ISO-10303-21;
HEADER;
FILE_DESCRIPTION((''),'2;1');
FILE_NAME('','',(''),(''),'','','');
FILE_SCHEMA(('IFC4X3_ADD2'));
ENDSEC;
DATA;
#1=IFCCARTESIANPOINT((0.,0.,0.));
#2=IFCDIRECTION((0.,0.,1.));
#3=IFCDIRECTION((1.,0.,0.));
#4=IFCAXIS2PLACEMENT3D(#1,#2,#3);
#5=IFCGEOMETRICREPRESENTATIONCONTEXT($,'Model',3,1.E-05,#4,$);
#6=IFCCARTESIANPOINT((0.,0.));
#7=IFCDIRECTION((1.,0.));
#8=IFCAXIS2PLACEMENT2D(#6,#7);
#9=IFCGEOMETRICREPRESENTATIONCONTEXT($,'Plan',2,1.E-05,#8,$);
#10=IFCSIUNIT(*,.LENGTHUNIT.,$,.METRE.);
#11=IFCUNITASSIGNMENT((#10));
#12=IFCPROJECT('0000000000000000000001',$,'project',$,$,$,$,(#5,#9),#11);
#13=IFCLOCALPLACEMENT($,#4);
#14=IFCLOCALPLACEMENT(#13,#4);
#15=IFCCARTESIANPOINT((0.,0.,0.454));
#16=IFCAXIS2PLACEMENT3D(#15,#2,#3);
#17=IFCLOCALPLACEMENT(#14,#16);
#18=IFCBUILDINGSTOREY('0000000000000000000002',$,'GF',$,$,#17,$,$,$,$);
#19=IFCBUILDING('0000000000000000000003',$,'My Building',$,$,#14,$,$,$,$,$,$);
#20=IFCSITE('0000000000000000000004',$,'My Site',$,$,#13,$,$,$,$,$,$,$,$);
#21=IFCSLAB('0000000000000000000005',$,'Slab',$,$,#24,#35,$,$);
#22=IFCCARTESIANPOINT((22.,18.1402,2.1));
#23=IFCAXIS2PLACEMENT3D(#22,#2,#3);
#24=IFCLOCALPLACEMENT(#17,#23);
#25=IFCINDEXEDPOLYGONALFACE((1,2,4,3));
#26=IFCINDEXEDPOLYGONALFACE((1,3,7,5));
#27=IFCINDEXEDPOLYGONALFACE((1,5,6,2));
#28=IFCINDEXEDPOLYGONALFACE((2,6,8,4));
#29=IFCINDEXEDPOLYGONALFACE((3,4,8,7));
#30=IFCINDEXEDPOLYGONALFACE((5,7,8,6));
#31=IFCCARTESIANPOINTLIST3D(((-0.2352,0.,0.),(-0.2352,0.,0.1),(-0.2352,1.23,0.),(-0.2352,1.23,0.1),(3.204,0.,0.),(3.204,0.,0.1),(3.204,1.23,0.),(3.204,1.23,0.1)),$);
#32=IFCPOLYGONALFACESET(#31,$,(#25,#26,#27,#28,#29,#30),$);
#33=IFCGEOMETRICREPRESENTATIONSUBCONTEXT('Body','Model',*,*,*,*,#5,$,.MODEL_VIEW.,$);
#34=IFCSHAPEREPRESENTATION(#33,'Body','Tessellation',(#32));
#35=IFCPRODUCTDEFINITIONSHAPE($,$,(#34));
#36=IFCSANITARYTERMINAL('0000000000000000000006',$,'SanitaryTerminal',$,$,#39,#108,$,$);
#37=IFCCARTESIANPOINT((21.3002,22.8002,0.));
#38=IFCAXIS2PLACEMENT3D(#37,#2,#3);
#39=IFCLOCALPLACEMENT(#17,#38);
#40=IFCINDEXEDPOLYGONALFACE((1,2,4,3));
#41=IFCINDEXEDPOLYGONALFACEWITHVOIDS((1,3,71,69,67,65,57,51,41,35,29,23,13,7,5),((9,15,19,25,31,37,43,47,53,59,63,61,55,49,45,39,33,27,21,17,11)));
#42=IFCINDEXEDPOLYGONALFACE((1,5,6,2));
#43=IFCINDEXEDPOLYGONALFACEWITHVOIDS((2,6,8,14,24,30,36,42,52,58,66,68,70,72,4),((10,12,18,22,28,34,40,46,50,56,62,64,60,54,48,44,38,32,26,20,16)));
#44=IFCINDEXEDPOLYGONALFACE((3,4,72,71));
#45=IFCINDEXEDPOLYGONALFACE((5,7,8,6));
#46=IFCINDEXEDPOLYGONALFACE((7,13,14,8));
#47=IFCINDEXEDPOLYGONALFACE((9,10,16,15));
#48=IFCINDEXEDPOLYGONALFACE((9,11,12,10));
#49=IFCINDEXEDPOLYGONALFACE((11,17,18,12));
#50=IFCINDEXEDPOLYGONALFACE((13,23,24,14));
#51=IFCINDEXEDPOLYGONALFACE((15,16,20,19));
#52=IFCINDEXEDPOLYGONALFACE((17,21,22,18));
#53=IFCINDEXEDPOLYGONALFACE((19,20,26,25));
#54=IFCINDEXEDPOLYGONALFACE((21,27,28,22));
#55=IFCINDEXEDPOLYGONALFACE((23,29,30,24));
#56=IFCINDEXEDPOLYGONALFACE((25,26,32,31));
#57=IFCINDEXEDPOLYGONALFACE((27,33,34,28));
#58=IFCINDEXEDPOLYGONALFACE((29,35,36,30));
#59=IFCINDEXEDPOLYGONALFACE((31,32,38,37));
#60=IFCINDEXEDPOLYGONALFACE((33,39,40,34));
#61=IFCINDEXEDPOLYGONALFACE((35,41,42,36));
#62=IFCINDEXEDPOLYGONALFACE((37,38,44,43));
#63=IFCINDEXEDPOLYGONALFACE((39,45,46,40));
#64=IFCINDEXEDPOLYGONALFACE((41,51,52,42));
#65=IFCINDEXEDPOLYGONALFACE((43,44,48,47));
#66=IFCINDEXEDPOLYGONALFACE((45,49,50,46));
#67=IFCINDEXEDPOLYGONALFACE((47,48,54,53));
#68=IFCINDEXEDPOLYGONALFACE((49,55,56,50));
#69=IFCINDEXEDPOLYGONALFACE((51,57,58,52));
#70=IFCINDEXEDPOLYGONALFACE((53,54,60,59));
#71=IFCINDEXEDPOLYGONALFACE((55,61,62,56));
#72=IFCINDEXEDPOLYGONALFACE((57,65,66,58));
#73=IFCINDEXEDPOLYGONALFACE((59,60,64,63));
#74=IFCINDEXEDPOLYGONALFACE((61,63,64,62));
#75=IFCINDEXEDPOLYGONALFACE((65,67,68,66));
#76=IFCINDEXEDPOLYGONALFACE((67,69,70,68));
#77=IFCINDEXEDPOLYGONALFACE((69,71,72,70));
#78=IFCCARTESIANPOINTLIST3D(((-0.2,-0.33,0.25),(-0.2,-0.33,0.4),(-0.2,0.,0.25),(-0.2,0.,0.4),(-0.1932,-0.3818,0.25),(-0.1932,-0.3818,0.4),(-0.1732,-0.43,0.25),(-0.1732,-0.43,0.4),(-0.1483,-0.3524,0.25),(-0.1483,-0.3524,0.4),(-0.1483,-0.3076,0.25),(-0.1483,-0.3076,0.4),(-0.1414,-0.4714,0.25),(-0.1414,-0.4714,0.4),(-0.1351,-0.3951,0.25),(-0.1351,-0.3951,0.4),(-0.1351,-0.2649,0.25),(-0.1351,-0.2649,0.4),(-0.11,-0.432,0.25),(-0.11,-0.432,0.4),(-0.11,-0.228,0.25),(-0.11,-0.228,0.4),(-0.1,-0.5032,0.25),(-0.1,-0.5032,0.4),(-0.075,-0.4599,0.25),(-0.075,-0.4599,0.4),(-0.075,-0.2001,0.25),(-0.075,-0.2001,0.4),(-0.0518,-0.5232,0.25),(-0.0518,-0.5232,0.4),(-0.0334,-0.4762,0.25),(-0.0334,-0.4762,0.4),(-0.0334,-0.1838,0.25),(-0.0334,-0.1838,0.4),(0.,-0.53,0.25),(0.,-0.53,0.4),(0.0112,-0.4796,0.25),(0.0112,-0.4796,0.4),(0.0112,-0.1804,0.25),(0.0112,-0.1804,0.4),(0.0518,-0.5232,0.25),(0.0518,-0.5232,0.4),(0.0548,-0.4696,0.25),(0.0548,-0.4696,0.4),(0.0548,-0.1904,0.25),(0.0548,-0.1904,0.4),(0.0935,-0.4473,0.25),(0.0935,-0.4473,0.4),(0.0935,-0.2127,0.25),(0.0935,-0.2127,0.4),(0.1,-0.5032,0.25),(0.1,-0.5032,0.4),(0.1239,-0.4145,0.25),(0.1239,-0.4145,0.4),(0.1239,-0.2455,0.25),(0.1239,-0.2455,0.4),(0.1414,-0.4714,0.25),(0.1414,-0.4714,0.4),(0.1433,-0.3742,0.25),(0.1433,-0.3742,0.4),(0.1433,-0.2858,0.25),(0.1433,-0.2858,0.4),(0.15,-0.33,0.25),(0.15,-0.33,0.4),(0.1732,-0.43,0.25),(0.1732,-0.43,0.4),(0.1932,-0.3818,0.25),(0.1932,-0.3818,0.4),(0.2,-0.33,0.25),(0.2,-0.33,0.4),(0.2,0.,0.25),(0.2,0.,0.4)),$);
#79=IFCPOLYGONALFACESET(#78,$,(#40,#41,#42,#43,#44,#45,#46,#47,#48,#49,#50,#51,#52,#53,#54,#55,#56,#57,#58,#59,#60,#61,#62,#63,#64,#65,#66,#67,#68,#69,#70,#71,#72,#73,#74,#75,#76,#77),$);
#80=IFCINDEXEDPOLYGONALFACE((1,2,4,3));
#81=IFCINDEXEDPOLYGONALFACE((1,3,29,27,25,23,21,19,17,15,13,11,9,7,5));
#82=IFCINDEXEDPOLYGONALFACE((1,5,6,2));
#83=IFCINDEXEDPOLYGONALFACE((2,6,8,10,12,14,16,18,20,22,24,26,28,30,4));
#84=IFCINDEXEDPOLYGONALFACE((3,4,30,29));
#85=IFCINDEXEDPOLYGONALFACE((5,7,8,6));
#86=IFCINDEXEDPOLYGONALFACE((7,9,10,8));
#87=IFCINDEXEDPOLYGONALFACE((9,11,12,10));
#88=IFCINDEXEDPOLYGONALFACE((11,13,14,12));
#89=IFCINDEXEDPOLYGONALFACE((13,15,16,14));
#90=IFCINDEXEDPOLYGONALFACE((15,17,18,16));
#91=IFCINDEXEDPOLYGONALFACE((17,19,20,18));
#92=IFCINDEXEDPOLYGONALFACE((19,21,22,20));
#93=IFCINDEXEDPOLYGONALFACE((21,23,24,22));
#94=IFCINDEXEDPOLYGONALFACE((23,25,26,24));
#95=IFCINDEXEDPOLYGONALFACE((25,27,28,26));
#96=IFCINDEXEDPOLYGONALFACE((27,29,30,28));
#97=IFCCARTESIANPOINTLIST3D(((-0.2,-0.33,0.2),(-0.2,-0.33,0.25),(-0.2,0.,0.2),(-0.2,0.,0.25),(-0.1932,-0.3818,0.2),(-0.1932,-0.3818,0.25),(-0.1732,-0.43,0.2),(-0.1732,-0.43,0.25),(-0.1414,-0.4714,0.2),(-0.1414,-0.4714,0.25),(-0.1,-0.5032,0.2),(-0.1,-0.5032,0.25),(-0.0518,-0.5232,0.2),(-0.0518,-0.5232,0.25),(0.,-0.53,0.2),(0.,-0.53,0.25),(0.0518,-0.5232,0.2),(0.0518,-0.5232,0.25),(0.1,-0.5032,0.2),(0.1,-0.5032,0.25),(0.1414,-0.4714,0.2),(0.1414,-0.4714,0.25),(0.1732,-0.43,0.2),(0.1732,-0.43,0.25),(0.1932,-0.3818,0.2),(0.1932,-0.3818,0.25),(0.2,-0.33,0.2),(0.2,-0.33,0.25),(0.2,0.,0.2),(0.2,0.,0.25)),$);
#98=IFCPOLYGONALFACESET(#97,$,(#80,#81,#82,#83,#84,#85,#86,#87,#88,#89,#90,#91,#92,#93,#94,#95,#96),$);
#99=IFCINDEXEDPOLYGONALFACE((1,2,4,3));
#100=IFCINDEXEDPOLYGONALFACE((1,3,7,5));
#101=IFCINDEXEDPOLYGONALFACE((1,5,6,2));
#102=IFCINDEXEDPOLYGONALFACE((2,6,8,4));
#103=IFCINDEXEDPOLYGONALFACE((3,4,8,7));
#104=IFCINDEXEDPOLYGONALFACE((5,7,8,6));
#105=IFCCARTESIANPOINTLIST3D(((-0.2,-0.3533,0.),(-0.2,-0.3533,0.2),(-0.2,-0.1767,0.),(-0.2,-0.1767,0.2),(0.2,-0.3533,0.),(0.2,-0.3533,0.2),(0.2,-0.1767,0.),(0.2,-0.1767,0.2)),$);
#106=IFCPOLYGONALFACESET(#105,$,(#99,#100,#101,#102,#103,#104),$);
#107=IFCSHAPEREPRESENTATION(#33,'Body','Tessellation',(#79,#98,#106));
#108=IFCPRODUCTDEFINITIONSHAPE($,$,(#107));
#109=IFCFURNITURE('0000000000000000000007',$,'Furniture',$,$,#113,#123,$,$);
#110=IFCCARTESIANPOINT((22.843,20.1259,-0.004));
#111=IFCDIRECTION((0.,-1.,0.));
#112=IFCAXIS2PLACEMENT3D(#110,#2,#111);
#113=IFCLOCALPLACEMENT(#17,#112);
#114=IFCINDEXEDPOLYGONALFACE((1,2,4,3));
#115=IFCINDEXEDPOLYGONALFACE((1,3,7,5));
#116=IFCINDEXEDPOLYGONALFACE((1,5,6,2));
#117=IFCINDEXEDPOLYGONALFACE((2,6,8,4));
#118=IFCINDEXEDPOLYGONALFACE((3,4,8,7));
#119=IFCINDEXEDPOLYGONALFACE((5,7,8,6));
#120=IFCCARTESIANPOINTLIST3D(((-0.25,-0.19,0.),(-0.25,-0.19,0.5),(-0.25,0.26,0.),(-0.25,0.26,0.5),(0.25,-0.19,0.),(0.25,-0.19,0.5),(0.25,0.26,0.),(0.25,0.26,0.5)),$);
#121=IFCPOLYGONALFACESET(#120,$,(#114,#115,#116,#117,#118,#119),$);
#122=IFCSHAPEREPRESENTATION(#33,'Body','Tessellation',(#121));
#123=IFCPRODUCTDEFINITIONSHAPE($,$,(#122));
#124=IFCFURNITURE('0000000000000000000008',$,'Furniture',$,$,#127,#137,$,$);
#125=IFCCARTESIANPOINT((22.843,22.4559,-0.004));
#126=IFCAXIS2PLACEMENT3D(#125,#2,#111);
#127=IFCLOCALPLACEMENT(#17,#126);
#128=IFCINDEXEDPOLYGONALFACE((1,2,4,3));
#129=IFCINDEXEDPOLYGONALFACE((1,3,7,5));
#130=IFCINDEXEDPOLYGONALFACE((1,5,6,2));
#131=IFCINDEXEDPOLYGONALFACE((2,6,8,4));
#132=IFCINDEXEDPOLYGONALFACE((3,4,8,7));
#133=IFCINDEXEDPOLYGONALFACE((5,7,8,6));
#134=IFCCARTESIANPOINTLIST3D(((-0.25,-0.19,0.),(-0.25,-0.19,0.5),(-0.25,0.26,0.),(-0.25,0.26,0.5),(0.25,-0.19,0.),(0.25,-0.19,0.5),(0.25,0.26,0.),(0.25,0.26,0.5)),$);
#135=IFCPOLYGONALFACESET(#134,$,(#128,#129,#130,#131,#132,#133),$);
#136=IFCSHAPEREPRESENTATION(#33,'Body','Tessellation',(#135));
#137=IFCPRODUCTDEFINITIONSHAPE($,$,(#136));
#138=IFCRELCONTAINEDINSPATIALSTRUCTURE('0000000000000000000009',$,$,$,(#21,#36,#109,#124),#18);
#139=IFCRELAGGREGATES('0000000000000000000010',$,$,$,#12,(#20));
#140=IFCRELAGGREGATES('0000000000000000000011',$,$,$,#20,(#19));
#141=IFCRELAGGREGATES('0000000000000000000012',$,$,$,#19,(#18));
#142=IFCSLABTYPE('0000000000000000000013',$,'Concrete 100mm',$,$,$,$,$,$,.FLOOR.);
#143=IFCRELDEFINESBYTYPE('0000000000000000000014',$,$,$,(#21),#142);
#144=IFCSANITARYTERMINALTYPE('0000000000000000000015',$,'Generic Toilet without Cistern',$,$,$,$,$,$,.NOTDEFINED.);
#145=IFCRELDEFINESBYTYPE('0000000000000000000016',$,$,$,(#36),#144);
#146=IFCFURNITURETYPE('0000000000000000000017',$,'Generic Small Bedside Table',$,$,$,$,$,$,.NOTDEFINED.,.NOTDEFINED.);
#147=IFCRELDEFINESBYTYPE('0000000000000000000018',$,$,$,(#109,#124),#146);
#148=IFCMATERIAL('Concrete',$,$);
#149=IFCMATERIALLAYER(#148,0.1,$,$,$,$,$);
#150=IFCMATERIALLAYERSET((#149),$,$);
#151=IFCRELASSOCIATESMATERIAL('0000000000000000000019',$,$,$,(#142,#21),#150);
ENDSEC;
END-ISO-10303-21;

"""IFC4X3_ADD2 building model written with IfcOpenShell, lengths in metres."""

from ifc_helpers import new_model, entity, si_unit, frame, frame_2d, origin_with_axes, origin_2d_with_axis, place, context, subcontext, project, spatial, line, arc, indexed_curve, circle_curve, outline, extrude, shape, source, transform, mapped, material, layer, layer_set, layer_usage, type_object, type_shapes, element, save


model = new_model("IFC4X3_ADD2")

# Units and contexts
model_context = context("Model", 3, precision=1e-05, world=origin_with_axes())
plan_context = context("Plan", 2, precision=1e-05, world=origin_2d_with_axis())
body_context_1 = subcontext(model_context, "Body", "Model", "MODEL_VIEW")
body_context_2 = subcontext(plan_context, "Body", "Plan", "PLAN_VIEW")
ifc_project = project(units=[si_unit("LENGTHUNIT", "METRE")], contexts=[model_context, plan_context])

# Site, building, storey
site_placement = place(None, origin_with_axes())
site = spatial("IfcSite", under=ifc_project, at=site_placement, Name="My Site")
building_placement = place(site_placement, origin_with_axes())
building = spatial("IfcBuilding", under=site, at=building_placement, Name="My Building")
storey_placement = place(building_placement, frame((0.0, 0.0, 0.454), z_axis=(0.0, 0.0, 1.0), x_axis=(1.0, 0.0, 0.0)))
storey = spatial("IfcBuildingStorey", under=building, at=storey_placement, Name="GF")

# Slab
ifc_material_1 = material(Name="Concrete")
ifc_layer_1 = layer(ifc_material_1, 0.1)
ifc_layer_set_1 = layer_set([ifc_layer_1])
ifc_layer_usage_1 = layer_usage(ifc_layer_set_1, "AXIS3", "POSITIVE", 0.0)
slab_type = type_object("IfcSlabType", Name="Concrete 100mm", PredefinedType="FLOOR", material=ifc_layer_set_1)
slab_placement = place(storey_placement, frame((22.0, 18.1402, 2.1), z_axis=(0.0, 0.0, 1.0), x_axis=(1.0, 0.0, 0.0)))
element("IfcSlab", 1, at=slab_placement, inside=storey, type_object=slab_type, material=ifc_layer_usage_1, Name="Slab", context=body_context_1, shape_type="SweptSolid", body=[
    extrude(outline(indexed_curve([(3.204, 0.0), (-0.2352, 0.0), (-0.2352, 1.23), (3.204, 1.23)], segments=[line(3, 2), line(2, 1), line(1, 4), line(4, 3)], self_intersect=False)), None, (0.0, 0.0, 1.0), 0.1),
])

# Sanitary terminal
sanitary_terminal_type_1 = type_object("IfcSanitaryTerminalType", Name="Generic Toilet without Cistern", PredefinedType="NOTDEFINED")
shared_shape_1 = source(origin_with_axes(), body_context_1, "Body", "SweptSolid", [
    extrude(outline(indexed_curve([(-0.2, 0.0), (0.2, 0.0), (0.2, -0.33), (0.1414, -0.4714), (0.0, -0.53), (-0.1414, -0.4714), (-0.2, -0.33)], segments=[line(1, 2), line(2, 3), arc(3, 4, 5), arc(5, 6, 7), line(7, 1)]), holes=[circle_curve(frame_2d((0.0, -0.33)), 0.15)]), frame((0.0, 0.0, 0.25), z_axis=(0.0, 0.0, 1.0), x_axis=(1.0, 0.0, 0.0)), (0.0, 0.0, 1.0), 0.15),
    extrude(outline(indexed_curve([(-0.2, 0.0), (0.2, 0.0), (0.2, -0.33), (0.1414, -0.4714), (0.0, -0.53), (-0.1414, -0.4714), (-0.2, -0.33)], segments=[line(1, 2), line(2, 3), arc(3, 4, 5), arc(5, 6, 7), line(7, 1)])), frame((0.0, 0.0, 0.2), z_axis=(0.0, 0.0, 1.0), x_axis=(1.0, 0.0, 0.0)), (0.0, 0.0, 1.0), 0.05),
    extrude(outline(indexed_curve([(-0.2, -0.1767), (0.2, -0.1767), (0.2, -0.3533), (-0.2, -0.3533)], segments=[line(1, 2, 3, 4, 1)])), origin_with_axes(), (0.0, 0.0, 1.0), 0.2),
])
shared_shape_2 = source(origin_with_axes(), body_context_2, "Body", "Annotation2D", [
    entity("IfcGeometricCurveSet", [entity("IfcIndexedPolyCurve", entity("IfcCartesianPointList2D", [[-0.1068, -0.124], [-0.0957, -0.1129], [-0.0804, -0.1088], [0.0804, -0.1088], [0.0957, -0.1129], [0.1068, -0.124], [0.1109, -0.1393], [0.1109, -0.3476], [0.1025, -0.3926], [0.0784, -0.4308], [0.0424, -0.4563], [0.0, -0.4652], [-0.0424, -0.4563], [-0.0784, -0.4308], [-0.1025, -0.3926], [-0.1109, -0.3476], [-0.1109, -0.1393]]), [entity("IfcLineIndex", [1, 2, 3, 4, 5, 6, 7, 8, 9, 10, 11, 12, 13, 14, 15, 16, 17, 1])]), entity("IfcIndexedPolyCurve", entity("IfcCartesianPointList2D", [[-0.1962, -0.2314], [-0.1848, -0.301], [-0.1764, -0.3339], [-0.1663, -0.3651], [-0.1546, -0.3944], [-0.1414, -0.4213], [-0.1269, -0.4458], [-0.1111, -0.4675], [-0.0943, -0.4862], [-0.0765, -0.5018], [-0.0581, -0.514], [-0.039, -0.5229], [-0.0196, -0.5282], [0.0, -0.53], [0.0196, -0.5282], [0.039, -0.5229], [0.0581, -0.514], [0.0765, -0.5018], [0.0943, -0.4862], [0.1111, -0.4675], [0.1269, -0.4458], [0.1414, -0.4213], [0.1546, -0.3944], [0.1663, -0.3651], [0.1764, -0.3339], [0.1848, -0.301], [0.1962, -0.2314], [0.2, -0.159], [0.1872, 0.0], [-0.1872, 0.0], [-0.2, -0.159]]), [entity("IfcLineIndex", [1, 2, 3, 4, 5, 6, 7, 8, 9, 10, 11, 12, 13, 14, 15, 16, 17, 18, 19, 20, 21, 22, 23, 24, 25, 26, 27, 28, 29, 30, 31, 1])])]),
])
type_shapes(sanitary_terminal_type_1, [shared_shape_1, shared_shape_2])
sanitary_terminal_1_placement = place(storey_placement, frame((21.3002, 22.8002, 0.0), z_axis=(0.0, 0.0, 1.0), x_axis=(1.0, 0.0, 0.0)))
element("IfcSanitaryTerminal", 2, at=sanitary_terminal_1_placement, inside=storey, type_object=sanitary_terminal_type_1, Name="SanitaryTerminal", shapes=[
    shape(body_context_1, "Body", "MappedRepresentation", [mapped(shared_shape_1, transform((0.0, 0.0, 0.0), x_axis=(1.0, 0.0, 0.0), y_axis=(0.0, 1.0, 0.0), z_axis=(0.0, 0.0, 1.0), scale=1.0))]),
    shape(body_context_2, "Body", "MappedRepresentation", [mapped(shared_shape_2, transform((0.0, 0.0, 0.0), x_axis=(1.0, 0.0, 0.0), y_axis=(0.0, 1.0, 0.0), z_axis=(0.0, 0.0, 1.0), scale=1.0))]),
])

# Furniture
furniture_type_1 = type_object("IfcFurnitureType", Name="Generic Small Bedside Table", AssemblyPlace="NOTDEFINED", PredefinedType="NOTDEFINED")
shared_shape_3 = source(origin_with_axes(), body_context_1, "Body", "SweptSolid", [
    extrude(outline(indexed_curve([(0.5, 0.45), (0.5, 0.0), (0.0, 0.0), (0.0, 0.45)], segments=[line(4, 1), line(1, 2), line(2, 3), line(3, 4)], self_intersect=False)), frame((-0.25, -0.19, 0.0), z_axis=(0.0, 0.0, 1.0), x_axis=(1.0, 0.0, 0.0)), (0.0, 0.0, 1.0), 0.5),
])
shared_shape_4 = source(origin_with_axes(), body_context_2, "Body", "Annotation2D", [
    entity("IfcGeometricCurveSet", [entity("IfcIndexedPolyCurve", entity("IfcCartesianPointList2D", [[-0.25, -0.19], [0.25, -0.19], [0.25, 0.26], [-0.25, 0.26]]), [entity("IfcLineIndex", [1, 2]), entity("IfcLineIndex", [2, 3]), entity("IfcLineIndex", [3, 4]), entity("IfcLineIndex", [4, 1])])]),
])
type_shapes(furniture_type_1, [shared_shape_3, shared_shape_4])
for number, where, z_axis, x_axis, name in (
    (3, (22.843, 20.1259, -0.004), (0.0, 0.0, 1.0), (0.0, -1.0, 0.0), "Furniture"),
    (4, (22.843, 22.4559, -0.004), (0.0, 0.0, 1.0), (0.0, -1.0, 0.0), "Furniture"),
):
    element("IfcFurniture", number, at=place(storey_placement, frame(where, z_axis=z_axis, x_axis=x_axis)), inside=storey, type_object=furniture_type_1, Name=name, shapes=[
        shape(body_context_1, "Body", "MappedRepresentation", [mapped(shared_shape_3, transform((0.0, 0.0, 0.0), x_axis=(1.0, 0.0, 0.0), y_axis=(0.0, 1.0, 0.0), z_axis=(0.0, 0.0, 1.0), scale=1.0))]),
        shape(body_context_2, "Body", "MappedRepresentation", [mapped(shared_shape_4, transform((0.0, 0.0, 0.0), x_axis=(1.0, 0.0, 0.0), y_axis=(0.0, 1.0, 0.0), z_axis=(0.0, 0.0, 1.0), scale=1.0))]),
    ])

save(model, "model.ifc")
